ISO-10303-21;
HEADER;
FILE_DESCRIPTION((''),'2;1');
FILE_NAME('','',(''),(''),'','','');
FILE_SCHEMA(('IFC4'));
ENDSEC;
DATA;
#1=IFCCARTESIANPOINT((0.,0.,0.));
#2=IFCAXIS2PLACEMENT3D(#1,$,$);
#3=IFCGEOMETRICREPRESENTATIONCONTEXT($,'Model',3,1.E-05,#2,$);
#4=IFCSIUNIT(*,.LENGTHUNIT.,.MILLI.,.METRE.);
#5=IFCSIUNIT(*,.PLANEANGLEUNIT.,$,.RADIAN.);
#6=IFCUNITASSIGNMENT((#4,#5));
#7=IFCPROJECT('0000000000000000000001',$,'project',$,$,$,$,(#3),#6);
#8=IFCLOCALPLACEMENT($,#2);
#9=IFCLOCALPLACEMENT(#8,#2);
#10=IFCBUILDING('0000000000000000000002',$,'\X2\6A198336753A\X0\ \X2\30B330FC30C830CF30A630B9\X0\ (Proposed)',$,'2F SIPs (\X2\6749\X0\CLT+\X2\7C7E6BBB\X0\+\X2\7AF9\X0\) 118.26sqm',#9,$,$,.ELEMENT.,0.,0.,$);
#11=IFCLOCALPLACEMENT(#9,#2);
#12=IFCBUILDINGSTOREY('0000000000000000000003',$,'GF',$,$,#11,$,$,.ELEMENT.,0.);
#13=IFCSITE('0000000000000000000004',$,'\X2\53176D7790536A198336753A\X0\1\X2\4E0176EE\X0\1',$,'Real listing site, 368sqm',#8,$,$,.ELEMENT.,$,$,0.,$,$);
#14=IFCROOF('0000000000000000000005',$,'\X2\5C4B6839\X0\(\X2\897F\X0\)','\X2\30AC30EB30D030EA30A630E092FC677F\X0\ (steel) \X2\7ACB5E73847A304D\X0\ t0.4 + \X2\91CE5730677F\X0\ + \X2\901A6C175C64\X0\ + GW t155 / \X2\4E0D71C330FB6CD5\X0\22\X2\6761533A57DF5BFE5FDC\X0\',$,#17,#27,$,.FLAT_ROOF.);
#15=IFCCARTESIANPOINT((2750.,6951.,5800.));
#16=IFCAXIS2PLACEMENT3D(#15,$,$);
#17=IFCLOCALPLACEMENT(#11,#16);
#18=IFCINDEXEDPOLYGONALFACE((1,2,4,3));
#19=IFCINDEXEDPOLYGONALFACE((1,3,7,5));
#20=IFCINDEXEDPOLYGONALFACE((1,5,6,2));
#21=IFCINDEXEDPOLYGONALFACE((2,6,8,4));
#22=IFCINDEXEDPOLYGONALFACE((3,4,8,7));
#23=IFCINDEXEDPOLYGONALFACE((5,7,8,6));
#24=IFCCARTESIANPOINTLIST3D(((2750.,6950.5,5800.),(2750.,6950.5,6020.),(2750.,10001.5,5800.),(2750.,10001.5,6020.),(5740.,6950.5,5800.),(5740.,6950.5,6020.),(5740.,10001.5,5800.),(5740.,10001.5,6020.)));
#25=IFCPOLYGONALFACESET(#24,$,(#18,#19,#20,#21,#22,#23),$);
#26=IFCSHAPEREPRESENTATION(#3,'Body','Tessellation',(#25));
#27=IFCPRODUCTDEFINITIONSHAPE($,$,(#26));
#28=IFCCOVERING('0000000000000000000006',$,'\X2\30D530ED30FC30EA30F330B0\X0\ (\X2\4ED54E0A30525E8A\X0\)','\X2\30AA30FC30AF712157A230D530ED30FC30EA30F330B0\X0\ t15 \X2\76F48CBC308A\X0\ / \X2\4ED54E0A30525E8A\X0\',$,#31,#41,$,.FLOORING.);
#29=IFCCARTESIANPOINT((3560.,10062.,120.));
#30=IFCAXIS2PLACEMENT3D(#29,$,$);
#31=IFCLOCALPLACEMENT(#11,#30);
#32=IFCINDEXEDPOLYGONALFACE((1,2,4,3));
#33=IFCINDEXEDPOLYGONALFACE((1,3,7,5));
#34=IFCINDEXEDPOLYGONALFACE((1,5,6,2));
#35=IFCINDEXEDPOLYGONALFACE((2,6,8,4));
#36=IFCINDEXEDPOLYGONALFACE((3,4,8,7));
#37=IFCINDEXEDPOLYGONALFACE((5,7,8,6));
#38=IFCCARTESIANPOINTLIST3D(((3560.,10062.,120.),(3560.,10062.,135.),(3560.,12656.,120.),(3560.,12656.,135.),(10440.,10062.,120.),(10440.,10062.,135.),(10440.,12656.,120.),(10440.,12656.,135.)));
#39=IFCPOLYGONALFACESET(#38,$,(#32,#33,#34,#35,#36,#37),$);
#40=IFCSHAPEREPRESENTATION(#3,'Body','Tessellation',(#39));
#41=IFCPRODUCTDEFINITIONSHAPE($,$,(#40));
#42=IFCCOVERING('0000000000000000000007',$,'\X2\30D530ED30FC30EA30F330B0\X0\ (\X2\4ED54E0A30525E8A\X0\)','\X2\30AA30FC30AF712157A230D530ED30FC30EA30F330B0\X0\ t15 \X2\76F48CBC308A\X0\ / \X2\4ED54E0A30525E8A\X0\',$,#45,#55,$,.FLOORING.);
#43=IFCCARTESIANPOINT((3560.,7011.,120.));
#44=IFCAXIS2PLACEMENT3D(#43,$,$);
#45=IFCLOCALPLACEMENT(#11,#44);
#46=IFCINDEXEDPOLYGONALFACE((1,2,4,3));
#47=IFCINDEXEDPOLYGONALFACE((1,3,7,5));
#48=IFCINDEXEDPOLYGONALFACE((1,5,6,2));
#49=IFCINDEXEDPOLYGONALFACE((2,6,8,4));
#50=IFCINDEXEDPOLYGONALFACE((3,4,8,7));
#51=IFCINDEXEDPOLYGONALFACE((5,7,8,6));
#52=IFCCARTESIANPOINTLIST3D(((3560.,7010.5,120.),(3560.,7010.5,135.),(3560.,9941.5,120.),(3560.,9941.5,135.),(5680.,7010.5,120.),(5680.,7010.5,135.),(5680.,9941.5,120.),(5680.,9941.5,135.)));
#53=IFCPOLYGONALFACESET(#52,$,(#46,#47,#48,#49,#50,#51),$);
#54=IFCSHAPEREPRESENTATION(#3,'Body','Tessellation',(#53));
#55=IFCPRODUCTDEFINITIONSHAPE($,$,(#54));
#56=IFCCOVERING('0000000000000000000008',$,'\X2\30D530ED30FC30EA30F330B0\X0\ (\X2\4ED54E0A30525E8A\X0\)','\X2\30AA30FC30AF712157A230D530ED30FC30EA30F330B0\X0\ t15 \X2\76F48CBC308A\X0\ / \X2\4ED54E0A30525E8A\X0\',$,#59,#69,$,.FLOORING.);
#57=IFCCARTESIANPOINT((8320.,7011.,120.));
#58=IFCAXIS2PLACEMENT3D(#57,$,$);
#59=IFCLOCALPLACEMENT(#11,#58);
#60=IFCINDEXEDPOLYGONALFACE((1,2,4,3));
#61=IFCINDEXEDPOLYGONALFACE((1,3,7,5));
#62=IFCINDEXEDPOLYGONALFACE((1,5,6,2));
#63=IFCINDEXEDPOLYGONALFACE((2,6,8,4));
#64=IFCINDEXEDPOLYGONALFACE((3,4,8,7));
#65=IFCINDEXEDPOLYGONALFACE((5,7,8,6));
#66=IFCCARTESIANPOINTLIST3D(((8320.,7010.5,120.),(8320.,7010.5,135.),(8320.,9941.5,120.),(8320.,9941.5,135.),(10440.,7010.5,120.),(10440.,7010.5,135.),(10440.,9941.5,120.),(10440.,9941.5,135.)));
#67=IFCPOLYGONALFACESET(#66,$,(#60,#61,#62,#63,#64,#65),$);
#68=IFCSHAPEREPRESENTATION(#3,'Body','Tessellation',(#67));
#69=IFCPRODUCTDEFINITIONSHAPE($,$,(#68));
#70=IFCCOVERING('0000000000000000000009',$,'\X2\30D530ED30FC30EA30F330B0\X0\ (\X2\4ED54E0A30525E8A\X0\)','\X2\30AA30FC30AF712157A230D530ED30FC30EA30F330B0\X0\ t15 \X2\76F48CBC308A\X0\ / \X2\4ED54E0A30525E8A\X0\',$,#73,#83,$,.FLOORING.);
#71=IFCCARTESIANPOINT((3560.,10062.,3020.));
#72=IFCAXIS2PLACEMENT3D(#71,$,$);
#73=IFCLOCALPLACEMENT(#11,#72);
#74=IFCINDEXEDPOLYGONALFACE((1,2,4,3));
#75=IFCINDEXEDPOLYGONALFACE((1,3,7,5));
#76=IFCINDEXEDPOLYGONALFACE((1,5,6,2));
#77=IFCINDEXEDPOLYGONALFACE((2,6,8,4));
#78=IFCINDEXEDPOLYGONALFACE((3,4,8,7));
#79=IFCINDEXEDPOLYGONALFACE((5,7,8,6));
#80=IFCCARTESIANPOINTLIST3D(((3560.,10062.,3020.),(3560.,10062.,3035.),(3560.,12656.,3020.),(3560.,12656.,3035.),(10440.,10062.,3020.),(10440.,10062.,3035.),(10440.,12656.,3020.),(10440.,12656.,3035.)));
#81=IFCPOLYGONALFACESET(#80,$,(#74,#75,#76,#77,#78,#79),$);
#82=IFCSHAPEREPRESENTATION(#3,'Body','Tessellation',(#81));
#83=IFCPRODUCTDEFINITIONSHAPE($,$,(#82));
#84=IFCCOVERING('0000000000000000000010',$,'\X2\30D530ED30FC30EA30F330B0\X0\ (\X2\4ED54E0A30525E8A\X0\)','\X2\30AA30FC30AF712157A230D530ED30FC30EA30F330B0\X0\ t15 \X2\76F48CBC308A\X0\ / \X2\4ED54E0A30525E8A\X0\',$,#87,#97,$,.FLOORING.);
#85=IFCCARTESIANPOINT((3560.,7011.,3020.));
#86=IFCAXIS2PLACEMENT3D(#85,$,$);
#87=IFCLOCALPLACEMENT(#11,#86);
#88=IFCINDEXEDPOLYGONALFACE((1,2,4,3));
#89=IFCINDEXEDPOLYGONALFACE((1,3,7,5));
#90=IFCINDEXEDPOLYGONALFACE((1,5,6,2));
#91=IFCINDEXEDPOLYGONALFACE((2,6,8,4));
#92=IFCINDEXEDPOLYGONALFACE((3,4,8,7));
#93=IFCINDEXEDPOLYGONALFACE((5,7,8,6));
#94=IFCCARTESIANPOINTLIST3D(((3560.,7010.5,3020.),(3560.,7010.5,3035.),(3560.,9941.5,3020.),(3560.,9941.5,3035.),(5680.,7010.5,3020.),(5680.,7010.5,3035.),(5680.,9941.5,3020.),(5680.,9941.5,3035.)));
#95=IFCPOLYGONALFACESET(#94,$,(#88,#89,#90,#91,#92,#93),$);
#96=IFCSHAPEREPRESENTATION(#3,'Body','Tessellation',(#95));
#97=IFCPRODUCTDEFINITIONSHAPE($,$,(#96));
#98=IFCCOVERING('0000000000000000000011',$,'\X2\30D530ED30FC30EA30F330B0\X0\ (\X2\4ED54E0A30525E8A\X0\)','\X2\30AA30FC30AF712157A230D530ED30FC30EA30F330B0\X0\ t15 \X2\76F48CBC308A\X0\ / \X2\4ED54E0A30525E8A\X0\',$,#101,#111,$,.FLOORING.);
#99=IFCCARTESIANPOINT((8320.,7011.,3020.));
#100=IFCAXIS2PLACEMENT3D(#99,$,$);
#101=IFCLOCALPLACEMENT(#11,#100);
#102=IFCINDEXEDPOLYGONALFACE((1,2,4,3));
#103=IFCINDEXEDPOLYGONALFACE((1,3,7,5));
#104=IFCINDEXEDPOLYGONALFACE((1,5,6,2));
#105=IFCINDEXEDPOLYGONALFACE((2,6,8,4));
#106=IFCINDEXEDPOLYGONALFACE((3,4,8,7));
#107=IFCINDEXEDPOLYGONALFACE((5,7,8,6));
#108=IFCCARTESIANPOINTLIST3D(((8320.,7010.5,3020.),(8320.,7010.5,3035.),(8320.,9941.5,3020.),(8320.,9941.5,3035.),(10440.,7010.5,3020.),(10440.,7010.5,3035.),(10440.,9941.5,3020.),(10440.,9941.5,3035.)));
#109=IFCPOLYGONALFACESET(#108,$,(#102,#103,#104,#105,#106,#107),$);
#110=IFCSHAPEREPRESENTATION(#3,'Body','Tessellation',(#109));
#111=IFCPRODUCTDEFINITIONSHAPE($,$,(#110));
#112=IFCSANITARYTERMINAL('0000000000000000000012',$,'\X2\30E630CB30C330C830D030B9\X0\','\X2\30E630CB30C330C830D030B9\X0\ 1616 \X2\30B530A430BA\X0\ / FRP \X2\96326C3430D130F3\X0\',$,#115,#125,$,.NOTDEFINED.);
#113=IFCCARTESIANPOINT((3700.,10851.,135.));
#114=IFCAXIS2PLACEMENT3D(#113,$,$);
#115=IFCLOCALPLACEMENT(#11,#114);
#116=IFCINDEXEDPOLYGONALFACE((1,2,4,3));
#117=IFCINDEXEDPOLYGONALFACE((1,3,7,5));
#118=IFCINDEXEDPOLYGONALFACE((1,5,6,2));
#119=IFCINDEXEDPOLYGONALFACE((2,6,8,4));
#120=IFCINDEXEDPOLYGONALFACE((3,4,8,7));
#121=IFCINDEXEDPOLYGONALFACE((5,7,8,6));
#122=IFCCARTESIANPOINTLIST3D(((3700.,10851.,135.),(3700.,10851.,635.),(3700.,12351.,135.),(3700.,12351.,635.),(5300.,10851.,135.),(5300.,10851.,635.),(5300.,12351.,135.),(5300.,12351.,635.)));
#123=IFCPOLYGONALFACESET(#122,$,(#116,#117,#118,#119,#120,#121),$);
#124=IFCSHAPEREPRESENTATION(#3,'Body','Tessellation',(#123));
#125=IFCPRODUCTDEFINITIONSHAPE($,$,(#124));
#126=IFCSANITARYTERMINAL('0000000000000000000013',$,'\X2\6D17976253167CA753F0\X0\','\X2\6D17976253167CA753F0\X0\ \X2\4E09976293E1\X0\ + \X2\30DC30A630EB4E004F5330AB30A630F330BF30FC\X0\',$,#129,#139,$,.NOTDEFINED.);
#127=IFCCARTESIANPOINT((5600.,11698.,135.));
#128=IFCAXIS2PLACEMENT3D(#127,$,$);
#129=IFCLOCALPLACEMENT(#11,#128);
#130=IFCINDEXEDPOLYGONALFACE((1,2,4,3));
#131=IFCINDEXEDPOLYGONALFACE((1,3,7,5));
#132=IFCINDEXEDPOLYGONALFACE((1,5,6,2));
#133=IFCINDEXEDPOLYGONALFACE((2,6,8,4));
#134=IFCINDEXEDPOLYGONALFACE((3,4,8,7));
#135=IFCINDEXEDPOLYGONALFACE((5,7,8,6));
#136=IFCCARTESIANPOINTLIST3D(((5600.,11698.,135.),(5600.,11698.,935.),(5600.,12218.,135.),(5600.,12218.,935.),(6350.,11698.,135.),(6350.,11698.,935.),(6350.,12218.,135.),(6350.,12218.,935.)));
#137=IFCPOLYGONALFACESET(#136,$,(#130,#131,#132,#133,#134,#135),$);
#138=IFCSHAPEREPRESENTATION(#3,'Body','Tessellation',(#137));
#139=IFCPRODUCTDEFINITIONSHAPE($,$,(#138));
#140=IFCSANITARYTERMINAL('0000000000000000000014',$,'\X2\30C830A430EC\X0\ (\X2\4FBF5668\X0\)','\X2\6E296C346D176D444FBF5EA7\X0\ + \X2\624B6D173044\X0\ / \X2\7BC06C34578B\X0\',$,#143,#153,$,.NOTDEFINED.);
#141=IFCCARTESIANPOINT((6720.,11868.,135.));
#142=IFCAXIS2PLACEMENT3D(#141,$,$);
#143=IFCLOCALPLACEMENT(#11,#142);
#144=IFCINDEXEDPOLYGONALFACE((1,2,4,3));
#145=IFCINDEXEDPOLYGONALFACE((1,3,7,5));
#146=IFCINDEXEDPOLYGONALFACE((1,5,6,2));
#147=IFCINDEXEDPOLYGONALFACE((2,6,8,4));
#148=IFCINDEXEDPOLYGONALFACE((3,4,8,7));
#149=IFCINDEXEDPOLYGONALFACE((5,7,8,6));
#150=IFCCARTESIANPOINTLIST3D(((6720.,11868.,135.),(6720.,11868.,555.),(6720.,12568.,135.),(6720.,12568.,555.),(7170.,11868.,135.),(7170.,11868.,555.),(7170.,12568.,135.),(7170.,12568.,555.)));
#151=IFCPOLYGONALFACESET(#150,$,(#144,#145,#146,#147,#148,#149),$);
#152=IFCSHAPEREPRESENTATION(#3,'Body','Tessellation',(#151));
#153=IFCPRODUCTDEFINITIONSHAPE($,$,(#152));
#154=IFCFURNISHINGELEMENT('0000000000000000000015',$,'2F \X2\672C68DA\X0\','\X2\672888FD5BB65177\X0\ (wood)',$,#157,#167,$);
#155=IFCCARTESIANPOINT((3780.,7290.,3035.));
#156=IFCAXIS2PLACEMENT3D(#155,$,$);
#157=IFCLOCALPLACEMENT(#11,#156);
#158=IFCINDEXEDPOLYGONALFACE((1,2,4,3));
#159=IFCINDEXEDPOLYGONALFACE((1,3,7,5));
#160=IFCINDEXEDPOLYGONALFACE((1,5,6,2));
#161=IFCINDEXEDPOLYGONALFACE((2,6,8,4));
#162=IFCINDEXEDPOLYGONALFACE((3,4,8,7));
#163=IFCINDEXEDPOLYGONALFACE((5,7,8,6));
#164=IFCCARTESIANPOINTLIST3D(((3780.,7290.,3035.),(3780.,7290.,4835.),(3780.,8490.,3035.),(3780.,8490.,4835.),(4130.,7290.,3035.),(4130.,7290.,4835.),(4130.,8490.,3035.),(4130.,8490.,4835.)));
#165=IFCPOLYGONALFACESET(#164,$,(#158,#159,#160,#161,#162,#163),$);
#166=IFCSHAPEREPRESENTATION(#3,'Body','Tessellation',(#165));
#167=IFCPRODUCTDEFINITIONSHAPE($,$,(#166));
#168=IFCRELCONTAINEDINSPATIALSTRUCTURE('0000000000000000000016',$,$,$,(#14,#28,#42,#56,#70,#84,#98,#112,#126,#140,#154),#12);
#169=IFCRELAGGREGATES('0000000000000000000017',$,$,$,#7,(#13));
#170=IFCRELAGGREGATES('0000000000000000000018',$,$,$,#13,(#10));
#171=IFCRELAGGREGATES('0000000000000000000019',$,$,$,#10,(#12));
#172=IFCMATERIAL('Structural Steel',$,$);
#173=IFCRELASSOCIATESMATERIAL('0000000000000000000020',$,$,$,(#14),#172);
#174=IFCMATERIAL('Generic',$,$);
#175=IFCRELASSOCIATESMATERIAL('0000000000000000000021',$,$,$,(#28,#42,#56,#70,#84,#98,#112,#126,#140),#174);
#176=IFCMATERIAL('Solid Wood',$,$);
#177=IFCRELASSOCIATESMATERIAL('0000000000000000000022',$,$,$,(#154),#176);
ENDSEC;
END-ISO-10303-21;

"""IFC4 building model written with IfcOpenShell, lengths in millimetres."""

from ifc_helpers import new_model, si_unit, frame, frame_2d, origin, place, context, project, spatial, rectangle, extrude, material, element, save


model = new_model("IFC4")

# Units and contexts
model_context = context("Model", 3, precision=1e-05, world=origin())
ifc_project = project(units=[si_unit("LENGTHUNIT", "METRE", prefix="MILLI"), si_unit("PLANEANGLEUNIT", "RADIAN")], contexts=[model_context])

# Site, building, storey
site_placement = place(None, origin())
site = spatial("IfcSite", under=ifc_project, at=site_placement, Name="北海道標茶町1丁目1", ObjectType="Real listing site, 368sqm", CompositionType="ELEMENT", RefElevation=0.0)
building_placement = place(site_placement, origin())
building = spatial("IfcBuilding", under=site, at=building_placement, Name="標茶町 コートハウス (Proposed)", ObjectType="2F SIPs (杉CLT+籾殻+竹) 118.26sqm", CompositionType="ELEMENT", ElevationOfRefHeight=0.0, ElevationOfTerrain=0.0)
storey_placement = place(building_placement, origin())
storey = spatial("IfcBuildingStorey", under=building, at=storey_placement, Name="GF", CompositionType="ELEMENT", Elevation=0.0)

# Shared definitions
ifc_material_1 = material(Name="Solid Wood")

# Shared definitions
ifc_material_2 = material(Name="Generic")

# Roof
ifc_material_3 = material(Name="Structural Steel")
roof_1_placement = place(storey_placement, frame((2750.0, 6951.0, 5800.0)))
element("IfcRoof", 1, at=roof_1_placement, inside=storey, material=ifc_material_3, Name="屋根(西)", Description="ガルバリウム鋼板 (steel) 立平葺き t0.4 + 野地板 + 通気層 + GW t155 / 不燃・法22条区域対応", PredefinedType="FLAT_ROOF", context=model_context, shape_type="SweptSolid", body=[
    extrude(rectangle(XDim=2990.0, YDim=3051.0, at=frame_2d((1495.0, 1525.0))), frame((2750.0, 6951.0, 5800.0)), (0.0, 0.0, 1.0), 220.0),
])

# Coverings
covering_1_placement = place(storey_placement, frame((3560.0, 10062.0, 120.0)))
element("IfcCovering", 2, at=covering_1_placement, inside=storey, material=ifc_material_2, Name="フローリング (仕上げ床)", Description="オーク無垢フローリング t15 直貼り / 仕上げ床", PredefinedType="FLOORING", context=model_context, shape_type="SweptSolid", body=[
    extrude(rectangle(XDim=6880.0, YDim=2594.0, at=frame_2d((3440.0, 1297.0))), frame((3560.0, 10062.0, 120.0)), (0.0, 0.0, 1.0), 15.0),
])
covering_2_placement = place(storey_placement, frame((3560.0, 7011.0, 120.0)))
element("IfcCovering", 3, at=covering_2_placement, inside=storey, material=ifc_material_2, Name="フローリング (仕上げ床)", Description="オーク無垢フローリング t15 直貼り / 仕上げ床", PredefinedType="FLOORING", context=model_context, shape_type="SweptSolid", body=[
    extrude(rectangle(XDim=2120.0, YDim=2931.0, at=frame_2d((1060.0, 1465.0))), frame((3560.0, 7011.0, 120.0)), (0.0, 0.0, 1.0), 15.0),
])
covering_3_placement = place(storey_placement, frame((8320.0, 7011.0, 120.0)))
element("IfcCovering", 4, at=covering_3_placement, inside=storey, material=ifc_material_2, Name="フローリング (仕上げ床)", Description="オーク無垢フローリング t15 直貼り / 仕上げ床", PredefinedType="FLOORING", context=model_context, shape_type="SweptSolid", body=[
    extrude(rectangle(XDim=2120.0, YDim=2931.0, at=frame_2d((1060.0, 1465.0))), frame((8320.0, 7011.0, 120.0)), (0.0, 0.0, 1.0), 15.0),
])
covering_4_placement = place(storey_placement, frame((3560.0, 10062.0, 3020.0)))
element("IfcCovering", 5, at=covering_4_placement, inside=storey, material=ifc_material_2, Name="フローリング (仕上げ床)", Description="オーク無垢フローリング t15 直貼り / 仕上げ床", PredefinedType="FLOORING", context=model_context, shape_type="SweptSolid", body=[
    extrude(rectangle(XDim=6880.0, YDim=2594.0, at=frame_2d((3440.0, 1297.0))), frame((3560.0, 10062.0, 3020.0)), (0.0, 0.0, 1.0), 15.0),
])
covering_5_placement = place(storey_placement, frame((3560.0, 7011.0, 3020.0)))
element("IfcCovering", 6, at=covering_5_placement, inside=storey, material=ifc_material_2, Name="フローリング (仕上げ床)", Description="オーク無垢フローリング t15 直貼り / 仕上げ床", PredefinedType="FLOORING", context=model_context, shape_type="SweptSolid", body=[
    extrude(rectangle(XDim=2120.0, YDim=2931.0, at=frame_2d((1060.0, 1465.0))), frame((3560.0, 7011.0, 3020.0)), (0.0, 0.0, 1.0), 15.0),
])
covering_6_placement = place(storey_placement, frame((8320.0, 7011.0, 3020.0)))
element("IfcCovering", 7, at=covering_6_placement, inside=storey, material=ifc_material_2, Name="フローリング (仕上げ床)", Description="オーク無垢フローリング t15 直貼り / 仕上げ床", PredefinedType="FLOORING", context=model_context, shape_type="SweptSolid", body=[
    extrude(rectangle(XDim=2120.0, YDim=2931.0, at=frame_2d((1060.0, 1465.0))), frame((8320.0, 7011.0, 3020.0)), (0.0, 0.0, 1.0), 15.0),
])

# Sanitary terminals
sanitary_terminal_1_placement = place(storey_placement, frame((3700.0, 10851.0, 135.0)))
element("IfcSanitaryTerminal", 8, at=sanitary_terminal_1_placement, inside=storey, material=ifc_material_2, Name="ユニットバス", Description="ユニットバス 1616 サイズ / FRP 防水パン", PredefinedType="NOTDEFINED", context=model_context, shape_type="SweptSolid", body=[
    extrude(rectangle(XDim=1600.0, YDim=1500.0, at=frame_2d((800.0, 750.0))), frame((3700.0, 10851.0, 135.0)), (0.0, 0.0, 1.0), 500.0),
])
sanitary_terminal_2_placement = place(storey_placement, frame((5600.0, 11698.0, 135.0)))
element("IfcSanitaryTerminal", 9, at=sanitary_terminal_2_placement, inside=storey, material=ifc_material_2, Name="洗面化粧台", Description="洗面化粧台 三面鏡 + ボウル一体カウンター", PredefinedType="NOTDEFINED", context=model_context, shape_type="SweptSolid", body=[
    extrude(rectangle(XDim=750.0, YDim=520.0, at=frame_2d((375.0, 260.0))), frame((5600.0, 11698.0, 135.0)), (0.0, 0.0, 1.0), 800.0),
])
sanitary_terminal_3_placement = place(storey_placement, frame((6720.0, 11868.0, 135.0)))
element("IfcSanitaryTerminal", 10, at=sanitary_terminal_3_placement, inside=storey, material=ifc_material_2, Name="トイレ (便器)", Description="温水洗浄便座 + 手洗い / 節水型", PredefinedType="NOTDEFINED", context=model_context, shape_type="SweptSolid", body=[
    extrude(rectangle(XDim=450.0, YDim=700.0, at=frame_2d((225.0, 350.0))), frame((6720.0, 11868.0, 135.0)), (0.0, 0.0, 1.0), 420.0),
])

# Furnishing element
furnishing_placement = place(storey_placement, frame((3780.0, 7290.0, 3035.0)))
element("IfcFurnishingElement", 11, at=furnishing_placement, inside=storey, material=ifc_material_1, Name="2F 本棚", Description="木製家具 (wood)", context=model_context, shape_type="SweptSolid", body=[
    extrude(rectangle(XDim=350.0, YDim=1200.0, at=frame_2d((175.0, 600.0))), frame((3780.0, 7290.0, 3035.0)), (0.0, 0.0, 1.0), 1800.0),
])

save(model, "model.ifc")
